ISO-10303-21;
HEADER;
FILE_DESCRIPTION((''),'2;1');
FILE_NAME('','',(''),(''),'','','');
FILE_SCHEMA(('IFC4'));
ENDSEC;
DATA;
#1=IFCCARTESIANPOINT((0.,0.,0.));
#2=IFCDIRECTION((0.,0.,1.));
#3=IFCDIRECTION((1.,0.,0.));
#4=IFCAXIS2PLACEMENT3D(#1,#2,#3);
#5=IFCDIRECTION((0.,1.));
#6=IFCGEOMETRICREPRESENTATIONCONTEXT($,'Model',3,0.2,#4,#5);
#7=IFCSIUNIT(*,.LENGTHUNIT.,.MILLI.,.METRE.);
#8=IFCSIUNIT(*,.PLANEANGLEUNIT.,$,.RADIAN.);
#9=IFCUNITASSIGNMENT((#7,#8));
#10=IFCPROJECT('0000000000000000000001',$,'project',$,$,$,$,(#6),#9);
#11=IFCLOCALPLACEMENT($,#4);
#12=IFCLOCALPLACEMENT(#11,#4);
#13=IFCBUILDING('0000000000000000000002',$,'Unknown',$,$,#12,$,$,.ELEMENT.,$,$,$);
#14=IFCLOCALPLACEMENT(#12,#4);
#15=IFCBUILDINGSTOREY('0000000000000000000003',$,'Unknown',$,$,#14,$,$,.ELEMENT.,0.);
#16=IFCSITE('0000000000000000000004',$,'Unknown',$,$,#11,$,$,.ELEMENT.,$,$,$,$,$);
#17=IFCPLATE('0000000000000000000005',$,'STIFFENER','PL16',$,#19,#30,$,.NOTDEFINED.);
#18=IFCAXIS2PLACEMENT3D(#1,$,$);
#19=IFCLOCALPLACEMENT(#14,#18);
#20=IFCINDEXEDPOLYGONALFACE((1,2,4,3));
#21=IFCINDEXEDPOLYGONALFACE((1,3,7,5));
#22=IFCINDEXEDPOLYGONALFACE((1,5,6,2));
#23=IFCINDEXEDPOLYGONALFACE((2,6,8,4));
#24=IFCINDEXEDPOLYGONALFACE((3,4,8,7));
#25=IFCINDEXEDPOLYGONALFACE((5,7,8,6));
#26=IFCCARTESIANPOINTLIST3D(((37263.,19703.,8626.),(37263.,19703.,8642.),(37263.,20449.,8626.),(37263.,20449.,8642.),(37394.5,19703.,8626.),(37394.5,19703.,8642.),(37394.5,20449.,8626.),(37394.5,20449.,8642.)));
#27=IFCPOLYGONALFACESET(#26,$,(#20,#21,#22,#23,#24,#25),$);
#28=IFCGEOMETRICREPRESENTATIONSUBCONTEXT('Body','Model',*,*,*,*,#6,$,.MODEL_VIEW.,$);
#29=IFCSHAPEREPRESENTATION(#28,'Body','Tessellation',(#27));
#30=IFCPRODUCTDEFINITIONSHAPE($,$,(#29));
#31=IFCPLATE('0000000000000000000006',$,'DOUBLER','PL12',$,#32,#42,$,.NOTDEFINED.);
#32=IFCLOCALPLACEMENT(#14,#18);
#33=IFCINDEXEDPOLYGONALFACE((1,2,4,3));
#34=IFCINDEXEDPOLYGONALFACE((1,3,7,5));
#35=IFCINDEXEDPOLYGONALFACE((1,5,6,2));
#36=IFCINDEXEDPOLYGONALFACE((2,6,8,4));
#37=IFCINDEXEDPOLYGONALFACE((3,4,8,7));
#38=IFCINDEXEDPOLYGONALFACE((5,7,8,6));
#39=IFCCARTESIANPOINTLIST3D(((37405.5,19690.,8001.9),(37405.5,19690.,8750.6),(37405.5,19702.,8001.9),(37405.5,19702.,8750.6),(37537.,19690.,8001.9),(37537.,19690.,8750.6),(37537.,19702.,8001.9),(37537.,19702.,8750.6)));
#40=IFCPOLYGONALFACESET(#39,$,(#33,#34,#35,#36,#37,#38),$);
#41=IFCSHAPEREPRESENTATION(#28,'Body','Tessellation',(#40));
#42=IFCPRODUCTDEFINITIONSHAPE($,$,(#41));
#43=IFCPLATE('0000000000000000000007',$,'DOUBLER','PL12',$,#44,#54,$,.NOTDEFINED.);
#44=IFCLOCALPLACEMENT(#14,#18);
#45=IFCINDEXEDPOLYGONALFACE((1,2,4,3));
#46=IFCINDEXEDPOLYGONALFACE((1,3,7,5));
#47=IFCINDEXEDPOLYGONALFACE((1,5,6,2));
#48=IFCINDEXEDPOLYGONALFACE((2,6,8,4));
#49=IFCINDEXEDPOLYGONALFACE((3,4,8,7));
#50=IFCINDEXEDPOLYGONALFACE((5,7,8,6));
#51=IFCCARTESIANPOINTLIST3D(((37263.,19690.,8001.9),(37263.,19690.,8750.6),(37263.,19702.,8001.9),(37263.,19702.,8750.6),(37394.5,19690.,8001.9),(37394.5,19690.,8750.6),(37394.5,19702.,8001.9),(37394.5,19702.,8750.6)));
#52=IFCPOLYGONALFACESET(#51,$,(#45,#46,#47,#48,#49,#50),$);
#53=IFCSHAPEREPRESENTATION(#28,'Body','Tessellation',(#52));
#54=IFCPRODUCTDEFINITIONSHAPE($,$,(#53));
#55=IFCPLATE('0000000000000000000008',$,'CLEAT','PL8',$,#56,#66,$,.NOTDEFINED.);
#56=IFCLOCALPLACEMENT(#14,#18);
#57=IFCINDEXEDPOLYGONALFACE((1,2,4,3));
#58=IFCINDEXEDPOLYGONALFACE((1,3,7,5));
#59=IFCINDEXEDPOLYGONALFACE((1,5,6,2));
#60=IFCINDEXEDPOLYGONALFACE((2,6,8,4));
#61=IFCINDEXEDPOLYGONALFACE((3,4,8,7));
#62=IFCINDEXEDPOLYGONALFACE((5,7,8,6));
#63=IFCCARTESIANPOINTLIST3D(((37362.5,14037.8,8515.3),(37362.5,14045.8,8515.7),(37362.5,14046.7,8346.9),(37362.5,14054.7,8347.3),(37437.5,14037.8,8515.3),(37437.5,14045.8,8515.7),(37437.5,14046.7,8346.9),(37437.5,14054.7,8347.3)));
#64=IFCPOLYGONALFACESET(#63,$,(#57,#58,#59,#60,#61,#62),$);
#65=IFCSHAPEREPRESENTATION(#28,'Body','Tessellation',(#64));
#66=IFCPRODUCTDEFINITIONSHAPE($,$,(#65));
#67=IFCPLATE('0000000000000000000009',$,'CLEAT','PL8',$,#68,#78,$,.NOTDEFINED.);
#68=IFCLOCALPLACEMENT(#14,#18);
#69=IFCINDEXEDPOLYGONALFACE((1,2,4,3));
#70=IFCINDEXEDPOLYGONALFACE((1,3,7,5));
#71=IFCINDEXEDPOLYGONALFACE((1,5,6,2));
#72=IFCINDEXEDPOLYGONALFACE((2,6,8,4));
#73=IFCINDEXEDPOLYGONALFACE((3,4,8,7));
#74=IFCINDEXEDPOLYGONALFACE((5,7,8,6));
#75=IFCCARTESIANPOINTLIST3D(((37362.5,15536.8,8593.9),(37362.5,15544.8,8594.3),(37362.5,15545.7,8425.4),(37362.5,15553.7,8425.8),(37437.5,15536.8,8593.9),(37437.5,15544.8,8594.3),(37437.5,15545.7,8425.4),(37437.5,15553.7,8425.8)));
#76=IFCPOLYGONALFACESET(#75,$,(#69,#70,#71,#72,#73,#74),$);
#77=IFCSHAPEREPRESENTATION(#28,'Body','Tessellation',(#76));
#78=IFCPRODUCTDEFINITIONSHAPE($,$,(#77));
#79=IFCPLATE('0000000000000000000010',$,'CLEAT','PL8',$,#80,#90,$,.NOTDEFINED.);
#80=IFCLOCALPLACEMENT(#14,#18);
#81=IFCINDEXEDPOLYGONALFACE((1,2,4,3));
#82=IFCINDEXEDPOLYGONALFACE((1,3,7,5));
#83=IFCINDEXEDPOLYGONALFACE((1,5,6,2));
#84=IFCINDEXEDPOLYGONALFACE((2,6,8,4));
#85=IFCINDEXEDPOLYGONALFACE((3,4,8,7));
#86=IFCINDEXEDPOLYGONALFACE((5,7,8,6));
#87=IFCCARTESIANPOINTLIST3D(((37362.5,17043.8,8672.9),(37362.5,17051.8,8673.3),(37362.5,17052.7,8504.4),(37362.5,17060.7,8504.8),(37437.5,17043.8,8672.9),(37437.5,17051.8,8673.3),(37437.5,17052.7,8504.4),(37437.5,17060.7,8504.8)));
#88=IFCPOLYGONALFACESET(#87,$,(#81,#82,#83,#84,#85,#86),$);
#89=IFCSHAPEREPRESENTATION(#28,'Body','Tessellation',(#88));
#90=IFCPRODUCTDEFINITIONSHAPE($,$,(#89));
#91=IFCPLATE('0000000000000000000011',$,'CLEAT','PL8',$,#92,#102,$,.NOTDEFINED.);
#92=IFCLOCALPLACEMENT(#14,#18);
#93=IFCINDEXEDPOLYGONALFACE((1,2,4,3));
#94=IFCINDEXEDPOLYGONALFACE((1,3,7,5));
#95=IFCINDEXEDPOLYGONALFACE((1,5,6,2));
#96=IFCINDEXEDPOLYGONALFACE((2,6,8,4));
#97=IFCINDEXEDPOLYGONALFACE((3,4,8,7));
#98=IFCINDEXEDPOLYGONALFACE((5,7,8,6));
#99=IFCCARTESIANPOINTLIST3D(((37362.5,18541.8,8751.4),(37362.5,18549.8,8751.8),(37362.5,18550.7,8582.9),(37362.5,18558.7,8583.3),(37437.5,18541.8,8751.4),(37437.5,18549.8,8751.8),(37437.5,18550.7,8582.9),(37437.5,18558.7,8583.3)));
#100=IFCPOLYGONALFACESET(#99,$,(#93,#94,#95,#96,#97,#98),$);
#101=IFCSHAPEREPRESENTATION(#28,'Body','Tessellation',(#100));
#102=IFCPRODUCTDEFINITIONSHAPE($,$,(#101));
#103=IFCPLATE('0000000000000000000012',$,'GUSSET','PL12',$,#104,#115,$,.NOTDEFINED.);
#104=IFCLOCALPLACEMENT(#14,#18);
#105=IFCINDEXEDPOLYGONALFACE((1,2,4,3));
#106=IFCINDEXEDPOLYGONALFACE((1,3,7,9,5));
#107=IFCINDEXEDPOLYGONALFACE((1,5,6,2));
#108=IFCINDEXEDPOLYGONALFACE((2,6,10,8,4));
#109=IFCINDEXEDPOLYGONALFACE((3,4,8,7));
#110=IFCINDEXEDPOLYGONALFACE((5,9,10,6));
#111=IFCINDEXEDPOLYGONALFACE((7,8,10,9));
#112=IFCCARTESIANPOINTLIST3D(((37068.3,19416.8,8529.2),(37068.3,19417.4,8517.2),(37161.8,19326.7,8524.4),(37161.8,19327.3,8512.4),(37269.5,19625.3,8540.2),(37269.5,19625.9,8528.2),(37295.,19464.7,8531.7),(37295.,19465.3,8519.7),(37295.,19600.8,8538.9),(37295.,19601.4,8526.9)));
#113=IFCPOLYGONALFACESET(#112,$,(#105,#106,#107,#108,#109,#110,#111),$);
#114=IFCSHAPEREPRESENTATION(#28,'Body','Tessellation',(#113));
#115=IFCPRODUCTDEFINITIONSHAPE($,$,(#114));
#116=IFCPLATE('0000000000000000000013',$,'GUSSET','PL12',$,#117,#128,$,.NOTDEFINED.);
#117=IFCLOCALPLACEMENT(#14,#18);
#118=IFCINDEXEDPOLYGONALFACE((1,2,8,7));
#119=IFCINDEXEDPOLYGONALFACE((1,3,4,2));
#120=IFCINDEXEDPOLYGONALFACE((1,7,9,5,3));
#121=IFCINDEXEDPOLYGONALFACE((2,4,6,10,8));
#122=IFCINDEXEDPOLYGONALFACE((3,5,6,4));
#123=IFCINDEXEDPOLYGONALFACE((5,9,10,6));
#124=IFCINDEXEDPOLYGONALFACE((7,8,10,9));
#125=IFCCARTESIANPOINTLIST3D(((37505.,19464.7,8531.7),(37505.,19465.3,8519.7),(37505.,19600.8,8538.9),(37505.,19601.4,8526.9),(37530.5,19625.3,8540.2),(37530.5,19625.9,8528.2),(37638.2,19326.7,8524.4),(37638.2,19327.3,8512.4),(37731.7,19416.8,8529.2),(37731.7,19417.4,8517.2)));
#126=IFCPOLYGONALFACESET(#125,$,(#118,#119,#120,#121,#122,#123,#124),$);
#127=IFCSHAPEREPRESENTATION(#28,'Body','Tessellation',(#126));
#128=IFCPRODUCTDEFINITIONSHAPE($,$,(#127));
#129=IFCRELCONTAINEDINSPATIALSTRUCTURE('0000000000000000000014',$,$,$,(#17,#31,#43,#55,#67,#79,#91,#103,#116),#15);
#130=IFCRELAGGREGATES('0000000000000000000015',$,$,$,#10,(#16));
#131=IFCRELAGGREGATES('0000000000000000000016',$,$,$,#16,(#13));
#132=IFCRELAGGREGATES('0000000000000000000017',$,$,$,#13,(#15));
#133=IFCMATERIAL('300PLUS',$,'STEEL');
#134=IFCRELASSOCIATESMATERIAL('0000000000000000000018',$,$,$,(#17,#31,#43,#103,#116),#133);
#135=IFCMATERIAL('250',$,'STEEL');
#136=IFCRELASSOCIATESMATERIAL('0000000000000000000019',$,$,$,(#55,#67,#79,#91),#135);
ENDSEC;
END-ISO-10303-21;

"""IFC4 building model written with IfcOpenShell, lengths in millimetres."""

from ifc_helpers import new_model, si_unit, direction, frame, origin_with_axes, place, context, subcontext, project, spatial, line, indexed_curve, outline, extrude, material, element, save


model = new_model("IFC4")

# Units and contexts
model_context = context("Model", 3, precision=0.2, world=origin_with_axes(), true_north=direction((0.0, 1.0)))
body_context = subcontext(model_context, "Body", "Model", "MODEL_VIEW")
ifc_project = project(units=[si_unit("LENGTHUNIT", "METRE", prefix="MILLI"), si_unit("PLANEANGLEUNIT", "RADIAN")], contexts=[model_context])

# Site, building, storey
site_placement = place(None, origin_with_axes())
site = spatial("IfcSite", under=ifc_project, at=site_placement, Name="Unknown", CompositionType="ELEMENT")
building_placement = place(site_placement, origin_with_axes())
building = spatial("IfcBuilding", under=site, at=building_placement, Name="Unknown", CompositionType="ELEMENT")
storey_placement = place(building_placement, origin_with_axes())
storey = spatial("IfcBuildingStorey", under=building, at=storey_placement, Name="Unknown", CompositionType="ELEMENT", Elevation=0.0)

# Shared definitions
ifc_material_1 = material(Name="300PLUS", Category="STEEL")

# Plates
ifc_material_2 = material(Name="250", Category="STEEL")
for number, where, z_axis, x_axis, name in (
    (1, (37394.5, 19703.0, 8634.0), (0.0, 0.0, 1.0), (0.0, 1.0, 0.0), "STIFFENER"),
):
    element("IfcPlate", number, at=place(storey_placement, frame(where, z_axis=z_axis, x_axis=x_axis)), inside=storey, material=ifc_material_1, Name=name, Description="PL16", PredefinedType="NOTDEFINED", context=body_context, shape_type="SolidModel", body=[
        extrude(outline(indexed_curve([(0.0, 0.0), (746.0, 0.0), (746.0, 131.5), (0.0, 131.5)], segments=[line(1, 2, 3, 4, 1)])), frame((0.0, 0.0, 8.0), z_axis=(0.0, 0.0, 1.0), x_axis=(1.0, 0.0, 0.0)), (0.0, 0.0, -1.0), 16.0),
    ])
for number, where, z_axis, x_axis, name in (
    (2, (37537.0, 19696.0, 8001.9), (0.0, 1.0, 0.0), (-1.0, 0.0, 0.0), "DOUBLER"),
    (3, (37394.5, 19696.0, 8001.9), (0.0, 1.0, 0.0), (-1.0, 0.0, 0.0), "DOUBLER"),
):
    element("IfcPlate", number, at=place(storey_placement, frame(where, z_axis=z_axis, x_axis=x_axis)), inside=storey, material=ifc_material_1, Name=name, Description="PL12", PredefinedType="NOTDEFINED", context=body_context, shape_type="SolidModel", body=[
        extrude(outline(indexed_curve([(0.0, 0.0), (131.5, 0.0), (131.5, 748.7), (0.0, 748.7)], segments=[line(1, 2, 3, 4, 1)])), frame((0.0, 0.0, 6.0), z_axis=(0.0, 0.0, 1.0), x_axis=(1.0, 0.0, 0.0)), (0.0, 0.0, -1.0), 12.0),
    ])
plate_1_placement = place(storey_placement, frame((37362.5, 14041.8, 8515.5), z_axis=(0.0, 0.998606, 0.052777), x_axis=(1.0, 0.0, 0.0)))
element("IfcPlate", 4, at=plate_1_placement, inside=storey, material=ifc_material_2, Name="CLEAT", Description="PL8", PredefinedType="NOTDEFINED", context=body_context, shape_type="SolidModel", body=[
    extrude(outline(indexed_curve([(0.0, 0.0), (75.0, 0.0), (75.0, 168.6), (0.0, 168.6)], segments=[line(1, 2, 3, 4, 1)])), frame((0.0, 0.0, 4.0), z_axis=(0.0, 0.0, 1.0), x_axis=(1.0, 0.0, 0.0)), (0.0, 0.0, -1.0), 8.0),
])
for number, where, z_axis, x_axis, name in (
    (5, (37362.5, 15540.8, 8594.1), (0.0, 0.998608, 0.052745), (1.0, 0.0, 0.0), "CLEAT"),
    (6, (37362.5, 17047.8, 8673.1), (0.0, 0.998608, 0.052745), (1.0, 0.0, 0.0), "CLEAT"),
    (7, (37362.5, 18545.8, 8751.6), (0.0, 0.998608, 0.052745), (1.0, 0.0, 0.0), "CLEAT"),
):
    element("IfcPlate", number, at=place(storey_placement, frame(where, z_axis=z_axis, x_axis=x_axis)), inside=storey, material=ifc_material_2, Name=name, Description="PL8", PredefinedType="NOTDEFINED", context=body_context, shape_type="SolidModel", body=[
        extrude(outline(indexed_curve([(0.0, 0.0), (75.0, 0.0), (75.0, 168.7), (0.0, 168.7)], segments=[line(1, 2, 3, 4, 1)])), frame((0.0, 0.0, 4.0), z_axis=(0.0, 0.0, 1.0), x_axis=(1.0, 0.0, 0.0)), (0.0, 0.0, -1.0), 8.0),
    ])
plate_2_placement = place(storey_placement, frame((37295.0, 19601.1, 8532.9), z_axis=(0.000153, -0.052828, 0.998604), x_axis=(-0.720618, 0.692358, 0.036737)))
element("IfcPlate", 8, at=plate_2_placement, inside=storey, material=ifc_material_1, Name="GUSSET", Description="PL12", PredefinedType="NOTDEFINED", context=body_context, shape_type="SolidModel", body=[
    extrude(outline(indexed_curve([(0.0, 0.0), (35.4, 0.0), (35.6, 290.0), (-94.3, 290.1), (-94.5, 98.2)], segments=[line(1, 2, 3, 4, 5, 1)])), frame((0.0, 0.0, 6.0), z_axis=(0.0, 0.0, 1.0), x_axis=(1.0, 0.0, 0.0)), (0.0, 0.0, -1.0), 12.0),
])
plate_3_placement = place(storey_placement, frame((37505.0, 19601.1, 8532.9), z_axis=(-0.000152, -0.052828, 0.998604), x_axis=(0.0, -0.998604, -0.052828)))
element("IfcPlate", 9, at=plate_3_placement, inside=storey, material=ifc_material_1, Name="GUSSET", Description="PL12", PredefinedType="NOTDEFINED", context=body_context, shape_type="SolidModel", body=[
    extrude(outline(indexed_curve([(0.0, 0.0), (136.3, 0.0), (274.5, 133.2), (184.3, 226.7), (-24.5, 25.5)], segments=[line(1, 2, 3, 4, 5, 1)])), frame((0.0, 0.0, 6.0), z_axis=(0.0, 0.0, 1.0), x_axis=(1.0, 0.0, 0.0)), (0.0, 0.0, -1.0), 12.0),
])

save(model, "model.ifc")
